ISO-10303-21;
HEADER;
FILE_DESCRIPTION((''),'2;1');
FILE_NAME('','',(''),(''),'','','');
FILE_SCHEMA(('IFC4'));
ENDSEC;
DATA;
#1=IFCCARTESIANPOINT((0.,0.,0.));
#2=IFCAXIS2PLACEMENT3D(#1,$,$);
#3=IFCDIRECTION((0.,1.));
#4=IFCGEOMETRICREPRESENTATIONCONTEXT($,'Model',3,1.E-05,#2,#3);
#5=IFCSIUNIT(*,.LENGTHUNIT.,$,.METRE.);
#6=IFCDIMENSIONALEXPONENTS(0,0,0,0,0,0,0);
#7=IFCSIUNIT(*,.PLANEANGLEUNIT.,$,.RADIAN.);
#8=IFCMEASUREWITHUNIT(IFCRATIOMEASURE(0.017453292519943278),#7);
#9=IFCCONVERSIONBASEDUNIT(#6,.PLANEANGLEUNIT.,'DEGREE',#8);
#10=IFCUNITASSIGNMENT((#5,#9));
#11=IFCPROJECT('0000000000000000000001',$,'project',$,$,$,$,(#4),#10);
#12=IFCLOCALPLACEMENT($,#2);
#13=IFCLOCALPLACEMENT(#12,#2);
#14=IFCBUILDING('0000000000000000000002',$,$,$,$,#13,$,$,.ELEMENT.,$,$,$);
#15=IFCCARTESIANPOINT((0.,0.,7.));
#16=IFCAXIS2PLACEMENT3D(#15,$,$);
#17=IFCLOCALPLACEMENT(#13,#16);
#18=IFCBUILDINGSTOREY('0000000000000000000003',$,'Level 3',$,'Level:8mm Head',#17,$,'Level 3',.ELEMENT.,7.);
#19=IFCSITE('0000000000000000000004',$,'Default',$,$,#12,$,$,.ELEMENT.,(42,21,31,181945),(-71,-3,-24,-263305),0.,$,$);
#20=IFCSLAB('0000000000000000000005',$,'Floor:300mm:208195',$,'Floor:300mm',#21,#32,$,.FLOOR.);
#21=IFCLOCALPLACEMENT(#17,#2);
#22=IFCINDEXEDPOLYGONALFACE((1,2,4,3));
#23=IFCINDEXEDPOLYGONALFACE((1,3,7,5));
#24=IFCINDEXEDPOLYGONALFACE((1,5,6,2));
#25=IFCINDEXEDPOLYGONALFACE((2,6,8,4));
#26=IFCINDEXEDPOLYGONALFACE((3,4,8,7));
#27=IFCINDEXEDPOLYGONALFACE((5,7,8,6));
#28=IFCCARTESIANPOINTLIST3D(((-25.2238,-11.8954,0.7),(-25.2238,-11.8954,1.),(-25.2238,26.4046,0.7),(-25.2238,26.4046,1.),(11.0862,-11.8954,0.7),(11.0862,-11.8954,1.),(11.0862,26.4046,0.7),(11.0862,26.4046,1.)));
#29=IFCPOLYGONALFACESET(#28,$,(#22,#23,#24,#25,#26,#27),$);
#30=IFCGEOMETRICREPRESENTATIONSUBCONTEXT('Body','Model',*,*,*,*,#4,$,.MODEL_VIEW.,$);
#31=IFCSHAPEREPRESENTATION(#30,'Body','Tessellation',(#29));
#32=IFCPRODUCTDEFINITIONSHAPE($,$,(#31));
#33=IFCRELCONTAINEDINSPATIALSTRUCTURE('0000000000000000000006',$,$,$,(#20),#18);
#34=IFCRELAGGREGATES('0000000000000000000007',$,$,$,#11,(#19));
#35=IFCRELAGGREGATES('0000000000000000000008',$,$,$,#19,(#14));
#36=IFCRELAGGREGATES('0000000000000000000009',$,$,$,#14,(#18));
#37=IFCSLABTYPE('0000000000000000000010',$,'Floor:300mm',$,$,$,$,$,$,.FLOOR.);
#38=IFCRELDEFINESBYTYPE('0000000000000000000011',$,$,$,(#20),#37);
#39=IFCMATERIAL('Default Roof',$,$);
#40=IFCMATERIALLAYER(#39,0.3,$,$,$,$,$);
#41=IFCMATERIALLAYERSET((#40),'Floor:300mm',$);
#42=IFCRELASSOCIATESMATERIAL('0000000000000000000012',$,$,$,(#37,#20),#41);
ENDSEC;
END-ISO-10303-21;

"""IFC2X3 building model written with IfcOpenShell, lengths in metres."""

from ifc_helpers import new_model, entity, si_unit, converted_unit, direction, frame, origin, origin_2d_with_axis, place, context, subcontext, project, spatial, rectangle, extrude, material, layer, layer_set, layer_usage, type_object, element, save


model = new_model("IFC2X3")

# Units and contexts
model_context = context("Model", 3, precision=1e-05, world=origin(), true_north=direction((0.0, 1.0)))
body_context = subcontext(model_context, "Body", "Model", "MODEL_VIEW")
ifc_project = project(units=[si_unit("LENGTHUNIT", "METRE"), converted_unit("PLANEANGLEUNIT", "DEGREE", entity("IfcRatioMeasure", 0.017453292519943278), si_unit("PLANEANGLEUNIT", "RADIAN"), dimensions=[0, 0, 0, 0, 0, 0, 0])], contexts=[model_context])

# Site, building, storey
site_placement = place(None, origin())
site = spatial("IfcSite", under=ifc_project, at=site_placement, Name="Default", CompositionType="ELEMENT", RefLatitude=(42, 21, 31, 181945), RefLongitude=(-71, -3, -24, -263305), RefElevation=0.0)
building_placement = place(site_placement, origin())
building = spatial("IfcBuilding", under=site, at=building_placement, CompositionType="ELEMENT")
storey_placement = place(building_placement, frame((0.0, 0.0, 7.0)))
storey = spatial("IfcBuildingStorey", under=building, at=storey_placement, Name="Level 3", ObjectType="Level:8mm Head", LongName="Level 3", CompositionType="ELEMENT", Elevation=7.0)

# Slab
ifc_material = material(Name="Default Roof")
ifc_layer = layer(ifc_material, 0.3)
ifc_layer_set = layer_set([ifc_layer], Name="Floor:300mm")
ifc_layer_usage = layer_usage(ifc_layer_set, "AXIS3", "POSITIVE", 0.0)
slab_type = type_object("IfcSlabType", Name="Floor:300mm", PredefinedType="FLOOR", material=ifc_layer_set)
slab_placement = place(storey_placement, origin())
element("IfcSlab", 1, at=slab_placement, inside=storey, type_object=slab_type, material=ifc_layer_usage, Name="Floor:300mm:208195", ObjectType="Floor:300mm", PredefinedType="FLOOR", context=body_context, shape_type="SweptSolid", body=[
    extrude(rectangle(XDim=38.3, YDim=36.31, at=origin_2d_with_axis()), frame((-7.0688, 7.2546, 1.0), z_axis=(0.0, 0.0, -1.0), x_axis=(0.0, 1.0, 0.0)), (0.0, 0.0, 1.0), 0.3),
])

save(model, "model.ifc")
